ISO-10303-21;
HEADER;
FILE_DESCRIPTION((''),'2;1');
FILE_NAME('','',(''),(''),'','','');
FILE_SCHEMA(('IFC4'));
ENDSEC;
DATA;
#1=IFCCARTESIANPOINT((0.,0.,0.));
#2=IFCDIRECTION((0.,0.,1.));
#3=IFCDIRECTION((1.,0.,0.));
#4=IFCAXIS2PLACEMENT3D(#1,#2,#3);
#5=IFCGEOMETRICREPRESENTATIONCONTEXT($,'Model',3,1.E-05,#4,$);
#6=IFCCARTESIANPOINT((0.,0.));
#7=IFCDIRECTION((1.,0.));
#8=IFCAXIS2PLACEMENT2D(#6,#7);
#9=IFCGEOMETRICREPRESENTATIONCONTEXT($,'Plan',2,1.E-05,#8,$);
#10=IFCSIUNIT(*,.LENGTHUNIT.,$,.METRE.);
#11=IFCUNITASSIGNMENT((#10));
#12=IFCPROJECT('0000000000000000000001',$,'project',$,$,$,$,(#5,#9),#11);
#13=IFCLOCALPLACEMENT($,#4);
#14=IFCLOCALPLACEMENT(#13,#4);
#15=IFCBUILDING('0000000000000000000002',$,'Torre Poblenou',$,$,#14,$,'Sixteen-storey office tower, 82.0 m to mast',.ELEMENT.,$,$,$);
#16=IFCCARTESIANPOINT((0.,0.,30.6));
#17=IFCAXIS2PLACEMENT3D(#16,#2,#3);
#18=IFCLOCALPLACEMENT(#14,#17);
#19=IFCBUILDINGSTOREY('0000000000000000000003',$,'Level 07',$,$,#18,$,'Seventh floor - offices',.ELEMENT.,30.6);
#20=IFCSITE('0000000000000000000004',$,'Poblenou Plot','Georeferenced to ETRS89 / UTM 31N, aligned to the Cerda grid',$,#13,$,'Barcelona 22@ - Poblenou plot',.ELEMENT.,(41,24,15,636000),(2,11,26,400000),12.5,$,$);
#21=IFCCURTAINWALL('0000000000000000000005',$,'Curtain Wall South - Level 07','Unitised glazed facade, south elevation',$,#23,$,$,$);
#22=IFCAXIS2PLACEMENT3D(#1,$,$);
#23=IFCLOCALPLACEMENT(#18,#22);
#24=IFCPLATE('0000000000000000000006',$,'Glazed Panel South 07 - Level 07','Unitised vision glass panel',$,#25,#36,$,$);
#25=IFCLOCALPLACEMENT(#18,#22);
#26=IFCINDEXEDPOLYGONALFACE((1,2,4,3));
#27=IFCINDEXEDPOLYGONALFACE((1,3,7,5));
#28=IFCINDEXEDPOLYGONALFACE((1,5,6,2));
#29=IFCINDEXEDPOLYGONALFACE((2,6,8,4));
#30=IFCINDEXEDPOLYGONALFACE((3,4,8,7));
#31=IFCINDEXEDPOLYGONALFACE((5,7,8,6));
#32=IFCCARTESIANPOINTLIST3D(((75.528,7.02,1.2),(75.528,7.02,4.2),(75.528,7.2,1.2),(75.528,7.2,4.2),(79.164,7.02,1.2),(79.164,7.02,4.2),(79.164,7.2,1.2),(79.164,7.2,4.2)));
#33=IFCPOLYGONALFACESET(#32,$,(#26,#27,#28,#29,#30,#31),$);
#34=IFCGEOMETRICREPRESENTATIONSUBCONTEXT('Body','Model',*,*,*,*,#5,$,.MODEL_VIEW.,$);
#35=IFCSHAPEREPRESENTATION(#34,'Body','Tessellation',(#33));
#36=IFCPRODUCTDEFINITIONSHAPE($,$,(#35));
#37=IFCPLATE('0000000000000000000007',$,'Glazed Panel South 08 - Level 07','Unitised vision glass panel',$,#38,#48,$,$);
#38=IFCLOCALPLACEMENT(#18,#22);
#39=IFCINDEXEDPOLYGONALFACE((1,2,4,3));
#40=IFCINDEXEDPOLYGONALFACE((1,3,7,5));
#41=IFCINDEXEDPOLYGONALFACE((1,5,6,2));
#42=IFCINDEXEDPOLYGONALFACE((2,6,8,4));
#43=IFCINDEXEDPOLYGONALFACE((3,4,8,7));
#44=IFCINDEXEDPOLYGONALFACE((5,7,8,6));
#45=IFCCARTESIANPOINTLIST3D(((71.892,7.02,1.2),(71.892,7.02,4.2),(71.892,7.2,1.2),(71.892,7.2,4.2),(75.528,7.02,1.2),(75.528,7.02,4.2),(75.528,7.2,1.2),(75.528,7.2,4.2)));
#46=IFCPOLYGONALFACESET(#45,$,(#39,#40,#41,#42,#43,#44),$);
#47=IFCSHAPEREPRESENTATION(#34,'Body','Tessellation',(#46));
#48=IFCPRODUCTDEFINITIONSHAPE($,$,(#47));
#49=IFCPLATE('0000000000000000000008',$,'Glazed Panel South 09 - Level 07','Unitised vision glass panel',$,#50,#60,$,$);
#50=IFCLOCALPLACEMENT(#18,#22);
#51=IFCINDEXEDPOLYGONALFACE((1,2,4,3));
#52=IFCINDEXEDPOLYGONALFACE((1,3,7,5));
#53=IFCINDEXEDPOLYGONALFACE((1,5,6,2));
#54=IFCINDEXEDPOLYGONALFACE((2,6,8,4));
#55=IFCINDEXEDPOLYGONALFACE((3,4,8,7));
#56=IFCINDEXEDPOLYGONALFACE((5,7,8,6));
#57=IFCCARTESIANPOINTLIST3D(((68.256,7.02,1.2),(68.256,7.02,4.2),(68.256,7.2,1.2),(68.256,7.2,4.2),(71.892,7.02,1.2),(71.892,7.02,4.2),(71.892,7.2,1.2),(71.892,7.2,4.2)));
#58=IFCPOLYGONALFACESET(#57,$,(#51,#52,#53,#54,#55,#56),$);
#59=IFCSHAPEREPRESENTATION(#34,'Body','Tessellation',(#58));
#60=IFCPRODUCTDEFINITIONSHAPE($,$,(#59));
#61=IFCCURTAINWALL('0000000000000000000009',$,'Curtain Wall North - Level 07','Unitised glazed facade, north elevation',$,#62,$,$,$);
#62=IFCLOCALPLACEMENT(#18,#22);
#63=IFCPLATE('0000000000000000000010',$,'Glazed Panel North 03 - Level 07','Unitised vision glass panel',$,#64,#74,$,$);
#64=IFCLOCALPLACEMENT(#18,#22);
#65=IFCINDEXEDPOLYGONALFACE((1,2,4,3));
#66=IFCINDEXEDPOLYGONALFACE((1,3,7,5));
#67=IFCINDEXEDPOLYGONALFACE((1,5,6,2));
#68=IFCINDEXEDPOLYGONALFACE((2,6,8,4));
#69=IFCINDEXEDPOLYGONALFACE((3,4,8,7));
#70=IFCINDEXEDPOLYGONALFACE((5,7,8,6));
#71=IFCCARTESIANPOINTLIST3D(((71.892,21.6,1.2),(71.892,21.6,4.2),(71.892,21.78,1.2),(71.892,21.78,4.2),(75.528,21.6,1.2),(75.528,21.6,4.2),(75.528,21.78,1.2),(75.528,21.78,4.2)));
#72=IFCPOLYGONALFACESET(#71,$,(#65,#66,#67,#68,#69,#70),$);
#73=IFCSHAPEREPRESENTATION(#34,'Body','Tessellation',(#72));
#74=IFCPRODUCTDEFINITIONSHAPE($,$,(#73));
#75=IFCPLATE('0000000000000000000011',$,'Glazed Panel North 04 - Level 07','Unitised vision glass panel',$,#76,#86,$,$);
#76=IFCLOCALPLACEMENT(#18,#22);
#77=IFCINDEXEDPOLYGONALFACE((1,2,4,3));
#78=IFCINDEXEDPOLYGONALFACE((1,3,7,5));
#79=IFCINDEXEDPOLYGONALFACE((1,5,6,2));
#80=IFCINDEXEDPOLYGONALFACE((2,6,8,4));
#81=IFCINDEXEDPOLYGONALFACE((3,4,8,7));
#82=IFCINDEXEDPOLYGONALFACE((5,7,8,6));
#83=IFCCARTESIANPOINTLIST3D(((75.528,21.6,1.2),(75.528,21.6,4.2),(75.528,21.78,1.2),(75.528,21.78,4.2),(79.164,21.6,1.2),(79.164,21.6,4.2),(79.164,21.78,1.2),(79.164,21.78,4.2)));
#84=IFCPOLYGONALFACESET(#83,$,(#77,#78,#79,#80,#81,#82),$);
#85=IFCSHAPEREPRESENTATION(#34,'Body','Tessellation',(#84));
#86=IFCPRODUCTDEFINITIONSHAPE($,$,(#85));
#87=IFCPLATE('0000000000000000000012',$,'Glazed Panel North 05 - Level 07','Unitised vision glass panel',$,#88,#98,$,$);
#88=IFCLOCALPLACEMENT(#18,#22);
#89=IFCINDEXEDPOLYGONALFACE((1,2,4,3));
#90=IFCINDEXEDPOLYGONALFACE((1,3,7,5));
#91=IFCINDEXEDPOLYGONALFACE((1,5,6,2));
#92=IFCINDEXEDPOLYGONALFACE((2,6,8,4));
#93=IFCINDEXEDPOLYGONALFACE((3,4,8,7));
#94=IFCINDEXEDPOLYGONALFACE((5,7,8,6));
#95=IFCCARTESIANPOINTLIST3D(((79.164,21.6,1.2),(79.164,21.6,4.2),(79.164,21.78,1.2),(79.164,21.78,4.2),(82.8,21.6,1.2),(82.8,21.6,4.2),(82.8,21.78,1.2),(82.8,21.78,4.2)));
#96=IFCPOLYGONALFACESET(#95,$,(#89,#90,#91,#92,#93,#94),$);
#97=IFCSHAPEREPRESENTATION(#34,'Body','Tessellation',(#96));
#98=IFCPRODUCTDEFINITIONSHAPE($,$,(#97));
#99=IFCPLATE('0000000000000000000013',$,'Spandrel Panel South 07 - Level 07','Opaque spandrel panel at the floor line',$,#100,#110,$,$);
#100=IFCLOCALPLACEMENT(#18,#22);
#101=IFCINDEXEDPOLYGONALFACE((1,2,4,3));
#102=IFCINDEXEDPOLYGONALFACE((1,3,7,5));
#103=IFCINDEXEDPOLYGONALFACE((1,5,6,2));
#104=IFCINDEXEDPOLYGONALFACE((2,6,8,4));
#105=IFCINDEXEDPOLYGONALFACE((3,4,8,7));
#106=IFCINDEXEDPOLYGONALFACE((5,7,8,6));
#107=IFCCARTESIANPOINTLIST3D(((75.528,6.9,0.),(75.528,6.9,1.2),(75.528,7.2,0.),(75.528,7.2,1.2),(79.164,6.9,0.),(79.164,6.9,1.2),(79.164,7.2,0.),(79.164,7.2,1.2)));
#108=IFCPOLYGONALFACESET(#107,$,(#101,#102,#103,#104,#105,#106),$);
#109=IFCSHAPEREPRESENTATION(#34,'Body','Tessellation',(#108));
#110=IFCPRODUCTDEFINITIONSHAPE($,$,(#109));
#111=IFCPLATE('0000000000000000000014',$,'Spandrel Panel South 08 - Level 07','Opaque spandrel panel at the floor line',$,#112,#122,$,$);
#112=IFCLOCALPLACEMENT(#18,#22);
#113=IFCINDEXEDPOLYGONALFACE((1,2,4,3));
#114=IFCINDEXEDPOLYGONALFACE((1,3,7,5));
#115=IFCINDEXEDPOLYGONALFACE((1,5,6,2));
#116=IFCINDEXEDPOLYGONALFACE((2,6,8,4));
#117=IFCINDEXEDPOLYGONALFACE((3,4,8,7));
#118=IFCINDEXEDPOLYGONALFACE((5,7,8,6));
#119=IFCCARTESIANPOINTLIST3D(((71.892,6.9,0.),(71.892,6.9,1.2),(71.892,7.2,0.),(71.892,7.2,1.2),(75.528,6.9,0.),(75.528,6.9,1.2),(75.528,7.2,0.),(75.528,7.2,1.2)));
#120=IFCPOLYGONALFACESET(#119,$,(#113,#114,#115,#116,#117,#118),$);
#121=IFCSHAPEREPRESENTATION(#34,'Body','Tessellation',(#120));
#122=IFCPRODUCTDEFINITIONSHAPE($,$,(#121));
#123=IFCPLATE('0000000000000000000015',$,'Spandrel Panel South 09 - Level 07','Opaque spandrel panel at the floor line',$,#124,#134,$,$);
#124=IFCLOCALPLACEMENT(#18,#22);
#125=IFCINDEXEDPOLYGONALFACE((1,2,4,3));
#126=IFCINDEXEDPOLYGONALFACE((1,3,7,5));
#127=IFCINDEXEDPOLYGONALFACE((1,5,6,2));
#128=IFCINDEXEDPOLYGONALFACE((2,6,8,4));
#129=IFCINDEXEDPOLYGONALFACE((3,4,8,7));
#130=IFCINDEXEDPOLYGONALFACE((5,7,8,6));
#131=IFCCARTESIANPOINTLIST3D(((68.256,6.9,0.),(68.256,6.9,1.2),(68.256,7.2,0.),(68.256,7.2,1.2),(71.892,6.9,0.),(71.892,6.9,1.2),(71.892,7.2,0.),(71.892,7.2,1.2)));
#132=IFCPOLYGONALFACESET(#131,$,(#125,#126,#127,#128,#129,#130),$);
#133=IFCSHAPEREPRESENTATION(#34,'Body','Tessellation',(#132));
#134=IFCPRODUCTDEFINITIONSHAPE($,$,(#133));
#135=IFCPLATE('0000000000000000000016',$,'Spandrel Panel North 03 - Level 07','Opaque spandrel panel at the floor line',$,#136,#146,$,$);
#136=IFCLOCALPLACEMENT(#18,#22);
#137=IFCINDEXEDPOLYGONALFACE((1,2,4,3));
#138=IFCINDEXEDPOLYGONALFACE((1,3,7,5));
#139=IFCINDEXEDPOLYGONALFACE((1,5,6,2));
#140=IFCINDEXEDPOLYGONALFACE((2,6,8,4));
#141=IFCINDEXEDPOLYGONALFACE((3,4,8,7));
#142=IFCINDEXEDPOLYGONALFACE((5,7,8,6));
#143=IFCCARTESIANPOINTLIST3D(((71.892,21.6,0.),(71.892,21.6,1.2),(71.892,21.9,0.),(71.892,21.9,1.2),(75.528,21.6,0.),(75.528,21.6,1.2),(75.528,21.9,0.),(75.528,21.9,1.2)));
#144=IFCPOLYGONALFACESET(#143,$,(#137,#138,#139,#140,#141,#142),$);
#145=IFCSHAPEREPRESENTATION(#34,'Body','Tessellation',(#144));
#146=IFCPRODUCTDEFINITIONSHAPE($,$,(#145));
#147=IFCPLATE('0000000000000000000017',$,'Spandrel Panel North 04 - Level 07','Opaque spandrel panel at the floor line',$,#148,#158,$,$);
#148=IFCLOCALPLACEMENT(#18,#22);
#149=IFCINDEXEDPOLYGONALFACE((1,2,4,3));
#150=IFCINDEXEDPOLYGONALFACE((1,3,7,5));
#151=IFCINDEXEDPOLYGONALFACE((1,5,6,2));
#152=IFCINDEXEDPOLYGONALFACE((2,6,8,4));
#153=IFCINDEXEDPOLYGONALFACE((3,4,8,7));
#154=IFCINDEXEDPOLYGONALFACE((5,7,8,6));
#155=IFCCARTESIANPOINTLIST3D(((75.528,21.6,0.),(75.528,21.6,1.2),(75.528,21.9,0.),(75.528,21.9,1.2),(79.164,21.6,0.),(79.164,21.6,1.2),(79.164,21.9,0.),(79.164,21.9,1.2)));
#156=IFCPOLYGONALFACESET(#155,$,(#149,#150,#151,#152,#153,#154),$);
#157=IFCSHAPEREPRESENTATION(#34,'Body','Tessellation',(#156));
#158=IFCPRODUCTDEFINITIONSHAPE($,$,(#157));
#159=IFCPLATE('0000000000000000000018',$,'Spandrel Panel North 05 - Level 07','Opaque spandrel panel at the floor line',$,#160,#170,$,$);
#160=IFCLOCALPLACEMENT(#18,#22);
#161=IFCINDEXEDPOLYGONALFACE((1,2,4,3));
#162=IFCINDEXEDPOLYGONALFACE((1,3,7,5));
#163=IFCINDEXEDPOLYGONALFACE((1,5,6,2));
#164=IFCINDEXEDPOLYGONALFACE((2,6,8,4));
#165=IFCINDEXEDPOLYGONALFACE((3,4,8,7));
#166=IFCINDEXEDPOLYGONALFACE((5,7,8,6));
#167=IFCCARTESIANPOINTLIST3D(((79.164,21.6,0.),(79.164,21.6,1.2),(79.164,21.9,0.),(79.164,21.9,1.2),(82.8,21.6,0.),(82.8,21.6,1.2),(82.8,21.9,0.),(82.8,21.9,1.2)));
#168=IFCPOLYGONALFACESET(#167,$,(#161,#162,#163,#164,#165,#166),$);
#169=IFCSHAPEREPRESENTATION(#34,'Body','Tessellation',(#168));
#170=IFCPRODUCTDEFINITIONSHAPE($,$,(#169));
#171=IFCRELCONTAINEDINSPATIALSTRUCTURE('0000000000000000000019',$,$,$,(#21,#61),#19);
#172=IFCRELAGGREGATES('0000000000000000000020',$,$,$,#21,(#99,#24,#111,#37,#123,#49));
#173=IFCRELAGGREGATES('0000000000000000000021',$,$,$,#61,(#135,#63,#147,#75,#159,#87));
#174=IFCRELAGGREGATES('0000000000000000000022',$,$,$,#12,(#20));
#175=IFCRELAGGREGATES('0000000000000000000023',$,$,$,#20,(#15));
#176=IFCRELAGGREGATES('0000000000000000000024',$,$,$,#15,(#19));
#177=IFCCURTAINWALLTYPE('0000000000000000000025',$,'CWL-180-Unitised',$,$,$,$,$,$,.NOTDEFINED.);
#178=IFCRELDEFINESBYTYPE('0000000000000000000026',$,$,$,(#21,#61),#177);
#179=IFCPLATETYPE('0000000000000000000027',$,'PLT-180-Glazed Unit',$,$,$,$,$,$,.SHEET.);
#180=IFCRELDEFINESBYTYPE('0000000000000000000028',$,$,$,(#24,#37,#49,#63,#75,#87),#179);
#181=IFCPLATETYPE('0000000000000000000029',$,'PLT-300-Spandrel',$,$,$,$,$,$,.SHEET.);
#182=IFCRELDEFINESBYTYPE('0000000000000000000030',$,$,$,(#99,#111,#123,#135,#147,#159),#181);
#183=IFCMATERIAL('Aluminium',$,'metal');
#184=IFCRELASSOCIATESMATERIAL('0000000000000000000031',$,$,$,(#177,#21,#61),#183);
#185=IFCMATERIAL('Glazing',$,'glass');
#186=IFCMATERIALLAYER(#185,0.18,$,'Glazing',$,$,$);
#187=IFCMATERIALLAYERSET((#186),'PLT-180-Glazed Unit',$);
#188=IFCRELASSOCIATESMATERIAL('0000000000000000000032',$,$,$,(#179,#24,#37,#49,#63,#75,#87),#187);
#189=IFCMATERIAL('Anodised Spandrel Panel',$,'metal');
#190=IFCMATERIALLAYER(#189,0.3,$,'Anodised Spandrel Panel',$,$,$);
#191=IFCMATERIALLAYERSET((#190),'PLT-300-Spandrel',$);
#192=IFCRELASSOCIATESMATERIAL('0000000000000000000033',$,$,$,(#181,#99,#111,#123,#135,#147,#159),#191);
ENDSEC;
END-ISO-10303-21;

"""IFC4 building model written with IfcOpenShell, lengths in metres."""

from ifc_helpers import new_model, si_unit, frame, origin_with_axes, origin_2d_with_axis, place, context, subcontext, project, spatial, line, indexed_curve, outline, extrude, material, layer, layer_set, layer_usage, type_object, element, aggregate, save


model = new_model("IFC4")

# Units and contexts
model_context = context("Model", 3, precision=1e-05, world=origin_with_axes())
plan_context = context("Plan", 2, precision=1e-05, world=origin_2d_with_axis())
body_context = subcontext(model_context, "Body", "Model", "MODEL_VIEW")
ifc_project = project(units=[si_unit("LENGTHUNIT", "METRE")], contexts=[model_context, plan_context])

# Site, building, storey
site_placement = place(None, origin_with_axes())
site = spatial("IfcSite", under=ifc_project, at=site_placement, Name="Poblenou Plot", Description="Georeferenced to ETRS89 / UTM 31N, aligned to the Cerda grid", LongName="Barcelona 22@ - Poblenou plot", CompositionType="ELEMENT", RefLatitude=(41, 24, 15, 636000), RefLongitude=(2, 11, 26, 400000), RefElevation=12.5)
building_placement = place(site_placement, origin_with_axes())
building = spatial("IfcBuilding", under=site, at=building_placement, Name="Torre Poblenou", LongName="Sixteen-storey office tower, 82.0 m to mast", CompositionType="ELEMENT")
storey_placement = place(building_placement, frame((0.0, 0.0, 30.6), z_axis=(0.0, 0.0, 1.0), x_axis=(1.0, 0.0, 0.0)))
storey = spatial("IfcBuildingStorey", under=building, at=storey_placement, Name="Level 07", LongName="Seventh floor - offices", CompositionType="ELEMENT", Elevation=30.6)

# Curtain walls, plates
ifc_material_1 = material(Name="Aluminium", Category="metal")
curtain_wall_type = type_object("IfcCurtainWallType", Name="CWL-180-Unitised", PredefinedType="NOTDEFINED", material=ifc_material_1)
curtain_wall_1_placement = place(storey_placement, frame((100.98, 7.2, 0.0), z_axis=(0.0, 0.0, 1.0), x_axis=(-1.0, 0.0, 0.0)))
curtain_wall_1 = element("IfcCurtainWall", 1, at=curtain_wall_1_placement, inside=storey, type_object=curtain_wall_type, material=ifc_material_1, Name="Curtain Wall South - Level 07", Description="Unitised glazed facade, south elevation")
ifc_material_2 = material(Name="Glazing", Category="glass")
ifc_layer_1 = layer(ifc_material_2, 0.18, Name="Glazing")
ifc_layer_set_1 = layer_set([ifc_layer_1], Name="PLT-180-Glazed Unit")
ifc_layer_usage_1 = layer_usage(ifc_layer_set_1, "AXIS2", "POSITIVE", 0.0)
plate_type_1 = type_object("IfcPlateType", Name="PLT-180-Glazed Unit", PredefinedType="SHEET", material=ifc_layer_set_1)
plate_1_placement = place(curtain_wall_1_placement, frame((21.816, 0.0, 1.2), z_axis=(0.0, 0.0, 1.0), x_axis=(1.0, 0.0, 0.0)))
plate_1 = element("IfcPlate", 2, at=plate_1_placement, type_object=plate_type_1, material=ifc_layer_usage_1, Name="Glazed Panel South 07 - Level 07", Description="Unitised vision glass panel", context=body_context, shape_type="SweptSolid", body=[
    extrude(outline(indexed_curve([(0.0, 0.0), (3.636, 0.0), (3.636, 0.18), (0.0, 0.18)], segments=[line(1, 2, 3, 4, 1)])), origin_with_axes(), (0.0, 0.0, 1.0), 3.0),
])
ifc_layer_usage_2 = layer_usage(ifc_layer_set_1, "AXIS2", "POSITIVE", 0.0)
plate_2_placement = place(curtain_wall_1_placement, frame((25.452, 0.0, 1.2), z_axis=(0.0, 0.0, 1.0), x_axis=(1.0, 0.0, 0.0)))
plate_2 = element("IfcPlate", 3, at=plate_2_placement, type_object=plate_type_1, material=ifc_layer_usage_2, Name="Glazed Panel South 08 - Level 07", Description="Unitised vision glass panel", context=body_context, shape_type="SweptSolid", body=[
    extrude(outline(indexed_curve([(0.0, 0.0), (3.636, 0.0), (3.636, 0.18), (0.0, 0.18)], segments=[line(1, 2, 3, 4, 1)])), origin_with_axes(), (0.0, 0.0, 1.0), 3.0),
])
ifc_layer_usage_3 = layer_usage(ifc_layer_set_1, "AXIS2", "POSITIVE", 0.0)
plate_3_placement = place(curtain_wall_1_placement, frame((29.088, 0.0, 1.2), z_axis=(0.0, 0.0, 1.0), x_axis=(1.0, 0.0, 0.0)))
plate_3 = element("IfcPlate", 4, at=plate_3_placement, type_object=plate_type_1, material=ifc_layer_usage_3, Name="Glazed Panel South 09 - Level 07", Description="Unitised vision glass panel", context=body_context, shape_type="SweptSolid", body=[
    extrude(outline(indexed_curve([(0.0, 0.0), (3.636, 0.0), (3.636, 0.18), (0.0, 0.18)], segments=[line(1, 2, 3, 4, 1)])), origin_with_axes(), (0.0, 0.0, 1.0), 3.0),
])
curtain_wall_2_placement = place(storey_placement, frame((64.62, 21.6, 0.0), z_axis=(0.0, 0.0, 1.0), x_axis=(1.0, 0.0, 0.0)))
curtain_wall_2 = element("IfcCurtainWall", 5, at=curtain_wall_2_placement, inside=storey, type_object=curtain_wall_type, material=ifc_material_1, Name="Curtain Wall North - Level 07", Description="Unitised glazed facade, north elevation")
ifc_layer_usage_4 = layer_usage(ifc_layer_set_1, "AXIS2", "POSITIVE", 0.0)
plate_4_placement = place(curtain_wall_2_placement, frame((7.272, 0.0, 1.2), z_axis=(0.0, 0.0, 1.0), x_axis=(1.0, 0.0, 0.0)))
plate_4 = element("IfcPlate", 6, at=plate_4_placement, type_object=plate_type_1, material=ifc_layer_usage_4, Name="Glazed Panel North 03 - Level 07", Description="Unitised vision glass panel", context=body_context, shape_type="SweptSolid", body=[
    extrude(outline(indexed_curve([(0.0, 0.0), (3.636, 0.0), (3.636, 0.18), (0.0, 0.18)], segments=[line(1, 2, 3, 4, 1)])), origin_with_axes(), (0.0, 0.0, 1.0), 3.0),
])
ifc_layer_usage_5 = layer_usage(ifc_layer_set_1, "AXIS2", "POSITIVE", 0.0)
plate_5_placement = place(curtain_wall_2_placement, frame((10.908, 0.0, 1.2), z_axis=(0.0, 0.0, 1.0), x_axis=(1.0, 0.0, 0.0)))
plate_5 = element("IfcPlate", 7, at=plate_5_placement, type_object=plate_type_1, material=ifc_layer_usage_5, Name="Glazed Panel North 04 - Level 07", Description="Unitised vision glass panel", context=body_context, shape_type="SweptSolid", body=[
    extrude(outline(indexed_curve([(0.0, 0.0), (3.636, 0.0), (3.636, 0.18), (0.0, 0.18)], segments=[line(1, 2, 3, 4, 1)])), origin_with_axes(), (0.0, 0.0, 1.0), 3.0),
])
ifc_layer_usage_6 = layer_usage(ifc_layer_set_1, "AXIS2", "POSITIVE", 0.0)
plate_6_placement = place(curtain_wall_2_placement, frame((14.544, 0.0, 1.2), z_axis=(0.0, 0.0, 1.0), x_axis=(1.0, 0.0, 0.0)))
plate_6 = element("IfcPlate", 8, at=plate_6_placement, type_object=plate_type_1, material=ifc_layer_usage_6, Name="Glazed Panel North 05 - Level 07", Description="Unitised vision glass panel", context=body_context, shape_type="SweptSolid", body=[
    extrude(outline(indexed_curve([(0.0, 0.0), (3.636, 0.0), (3.636, 0.18), (0.0, 0.18)], segments=[line(1, 2, 3, 4, 1)])), origin_with_axes(), (0.0, 0.0, 1.0), 3.0),
])

# Plates
ifc_material_3 = material(Name="Anodised Spandrel Panel", Category="metal")
ifc_layer_2 = layer(ifc_material_3, 0.3, Name="Anodised Spandrel Panel")
ifc_layer_set_2 = layer_set([ifc_layer_2], Name="PLT-300-Spandrel")
ifc_layer_usage_7 = layer_usage(ifc_layer_set_2, "AXIS2", "POSITIVE", 0.0)
plate_type_2 = type_object("IfcPlateType", Name="PLT-300-Spandrel", PredefinedType="SHEET", material=ifc_layer_set_2)
plate_7_placement = place(curtain_wall_1_placement, frame((21.816, 0.0, 0.0), z_axis=(0.0, 0.0, 1.0), x_axis=(1.0, 0.0, 0.0)))
plate_7 = element("IfcPlate", 9, at=plate_7_placement, type_object=plate_type_2, material=ifc_layer_usage_7, Name="Spandrel Panel South 07 - Level 07", Description="Opaque spandrel panel at the floor line", context=body_context, shape_type="SweptSolid", body=[
    extrude(outline(indexed_curve([(0.0, 0.0), (3.636, 0.0), (3.636, 0.3), (0.0, 0.3)], segments=[line(1, 2, 3, 4, 1)])), origin_with_axes(), (0.0, 0.0, 1.0), 1.2),
])
ifc_layer_usage_8 = layer_usage(ifc_layer_set_2, "AXIS2", "POSITIVE", 0.0)
plate_8_placement = place(curtain_wall_1_placement, frame((25.452, 0.0, 0.0), z_axis=(0.0, 0.0, 1.0), x_axis=(1.0, 0.0, 0.0)))
plate_8 = element("IfcPlate", 10, at=plate_8_placement, type_object=plate_type_2, material=ifc_layer_usage_8, Name="Spandrel Panel South 08 - Level 07", Description="Opaque spandrel panel at the floor line", context=body_context, shape_type="SweptSolid", body=[
    extrude(outline(indexed_curve([(0.0, 0.0), (3.636, 0.0), (3.636, 0.3), (0.0, 0.3)], segments=[line(1, 2, 3, 4, 1)])), origin_with_axes(), (0.0, 0.0, 1.0), 1.2),
])
ifc_layer_usage_9 = layer_usage(ifc_layer_set_2, "AXIS2", "POSITIVE", 0.0)
plate_9_placement = place(curtain_wall_1_placement, frame((29.088, 0.0, 0.0), z_axis=(0.0, 0.0, 1.0), x_axis=(1.0, 0.0, 0.0)))
plate_9 = element("IfcPlate", 11, at=plate_9_placement, type_object=plate_type_2, material=ifc_layer_usage_9, Name="Spandrel Panel South 09 - Level 07", Description="Opaque spandrel panel at the floor line", context=body_context, shape_type="SweptSolid", body=[
    extrude(outline(indexed_curve([(0.0, 0.0), (3.636, 0.0), (3.636, 0.3), (0.0, 0.3)], segments=[line(1, 2, 3, 4, 1)])), origin_with_axes(), (0.0, 0.0, 1.0), 1.2),
])
aggregate(curtain_wall_1, [plate_7, plate_1, plate_8, plate_2, plate_9, plate_3])
ifc_layer_usage_10 = layer_usage(ifc_layer_set_2, "AXIS2", "POSITIVE", 0.0)
plate_10_placement = place(curtain_wall_2_placement, frame((7.272, 0.0, 0.0), z_axis=(0.0, 0.0, 1.0), x_axis=(1.0, 0.0, 0.0)))
plate_10 = element("IfcPlate", 12, at=plate_10_placement, type_object=plate_type_2, material=ifc_layer_usage_10, Name="Spandrel Panel North 03 - Level 07", Description="Opaque spandrel panel at the floor line", context=body_context, shape_type="SweptSolid", body=[
    extrude(outline(indexed_curve([(0.0, 0.0), (3.636, 0.0), (3.636, 0.3), (0.0, 0.3)], segments=[line(1, 2, 3, 4, 1)])), origin_with_axes(), (0.0, 0.0, 1.0), 1.2),
])
ifc_layer_usage_11 = layer_usage(ifc_layer_set_2, "AXIS2", "POSITIVE", 0.0)
plate_11_placement = place(curtain_wall_2_placement, frame((10.908, 0.0, 0.0), z_axis=(0.0, 0.0, 1.0), x_axis=(1.0, 0.0, 0.0)))
plate_11 = element("IfcPlate", 13, at=plate_11_placement, type_object=plate_type_2, material=ifc_layer_usage_11, Name="Spandrel Panel North 04 - Level 07", Description="Opaque spandrel panel at the floor line", context=body_context, shape_type="SweptSolid", body=[
    extrude(outline(indexed_curve([(0.0, 0.0), (3.636, 0.0), (3.636, 0.3), (0.0, 0.3)], segments=[line(1, 2, 3, 4, 1)])), origin_with_axes(), (0.0, 0.0, 1.0), 1.2),
])
ifc_layer_usage_12 = layer_usage(ifc_layer_set_2, "AXIS2", "POSITIVE", 0.0)
plate_12_placement = place(curtain_wall_2_placement, frame((14.544, 0.0, 0.0), z_axis=(0.0, 0.0, 1.0), x_axis=(1.0, 0.0, 0.0)))
plate_12 = element("IfcPlate", 14, at=plate_12_placement, type_object=plate_type_2, material=ifc_layer_usage_12, Name="Spandrel Panel North 05 - Level 07", Description="Opaque spandrel panel at the floor line", context=body_context, shape_type="SweptSolid", body=[
    extrude(outline(indexed_curve([(0.0, 0.0), (3.636, 0.0), (3.636, 0.3), (0.0, 0.3)], segments=[line(1, 2, 3, 4, 1)])), origin_with_axes(), (0.0, 0.0, 1.0), 1.2),
])
aggregate(curtain_wall_2, [plate_10, plate_4, plate_11, plate_5, plate_12, plate_6])

save(model, "model.ifc")
